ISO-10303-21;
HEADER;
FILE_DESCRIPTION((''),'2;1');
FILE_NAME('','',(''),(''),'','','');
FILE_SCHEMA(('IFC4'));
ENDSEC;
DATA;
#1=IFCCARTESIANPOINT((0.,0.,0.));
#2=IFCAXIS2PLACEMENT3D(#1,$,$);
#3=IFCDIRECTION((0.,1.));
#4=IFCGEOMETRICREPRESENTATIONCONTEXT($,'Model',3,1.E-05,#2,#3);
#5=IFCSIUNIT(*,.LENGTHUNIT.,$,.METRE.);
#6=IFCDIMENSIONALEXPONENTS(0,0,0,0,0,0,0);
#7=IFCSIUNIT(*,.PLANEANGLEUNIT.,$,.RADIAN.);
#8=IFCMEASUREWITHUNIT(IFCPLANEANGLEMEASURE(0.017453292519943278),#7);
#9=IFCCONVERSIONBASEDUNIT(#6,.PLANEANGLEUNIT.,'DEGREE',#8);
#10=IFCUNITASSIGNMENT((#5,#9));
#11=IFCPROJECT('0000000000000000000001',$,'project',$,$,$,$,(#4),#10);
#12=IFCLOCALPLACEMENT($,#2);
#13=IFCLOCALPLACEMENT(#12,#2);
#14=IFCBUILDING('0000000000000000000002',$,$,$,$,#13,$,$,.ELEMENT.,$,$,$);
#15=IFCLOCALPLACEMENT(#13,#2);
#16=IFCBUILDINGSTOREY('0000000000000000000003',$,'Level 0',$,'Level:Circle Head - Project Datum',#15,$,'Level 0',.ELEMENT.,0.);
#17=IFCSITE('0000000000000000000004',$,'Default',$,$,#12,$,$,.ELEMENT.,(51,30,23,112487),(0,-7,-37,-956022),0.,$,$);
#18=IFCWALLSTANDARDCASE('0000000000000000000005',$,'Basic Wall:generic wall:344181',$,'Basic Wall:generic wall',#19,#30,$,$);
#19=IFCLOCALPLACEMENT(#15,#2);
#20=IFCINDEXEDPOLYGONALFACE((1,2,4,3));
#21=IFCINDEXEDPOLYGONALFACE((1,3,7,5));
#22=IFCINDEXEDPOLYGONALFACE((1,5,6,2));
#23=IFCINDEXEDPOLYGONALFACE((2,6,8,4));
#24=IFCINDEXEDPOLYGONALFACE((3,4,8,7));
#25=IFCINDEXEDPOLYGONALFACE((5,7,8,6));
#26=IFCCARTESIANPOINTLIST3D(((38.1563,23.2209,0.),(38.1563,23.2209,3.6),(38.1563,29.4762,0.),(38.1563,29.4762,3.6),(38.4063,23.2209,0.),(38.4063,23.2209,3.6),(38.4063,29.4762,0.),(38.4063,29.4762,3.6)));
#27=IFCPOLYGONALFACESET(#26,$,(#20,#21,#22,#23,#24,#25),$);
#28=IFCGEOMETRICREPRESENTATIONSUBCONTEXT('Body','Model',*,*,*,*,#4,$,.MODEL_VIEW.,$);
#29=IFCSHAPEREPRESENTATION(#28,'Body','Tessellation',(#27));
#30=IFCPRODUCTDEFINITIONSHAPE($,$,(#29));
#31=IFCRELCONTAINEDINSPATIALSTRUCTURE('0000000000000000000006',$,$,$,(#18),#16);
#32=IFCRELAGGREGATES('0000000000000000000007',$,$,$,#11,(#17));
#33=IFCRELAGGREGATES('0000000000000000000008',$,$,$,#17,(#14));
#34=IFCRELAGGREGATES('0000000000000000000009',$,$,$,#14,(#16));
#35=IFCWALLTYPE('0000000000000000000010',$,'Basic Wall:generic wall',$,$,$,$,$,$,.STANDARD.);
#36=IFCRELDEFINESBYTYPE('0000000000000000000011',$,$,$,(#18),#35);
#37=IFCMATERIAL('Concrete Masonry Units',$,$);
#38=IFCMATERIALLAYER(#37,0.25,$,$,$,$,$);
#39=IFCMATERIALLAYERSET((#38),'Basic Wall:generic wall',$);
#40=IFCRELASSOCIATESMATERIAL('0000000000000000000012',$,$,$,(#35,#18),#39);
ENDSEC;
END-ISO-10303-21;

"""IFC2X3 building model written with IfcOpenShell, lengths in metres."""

from ifc_helpers import new_model, entity, si_unit, converted_unit, direction, frame, frame_2d, origin, place, context, subcontext, project, spatial, rectangle, extrude, material, layer, layer_set, layer_usage, type_object, element, save


model = new_model("IFC2X3")

# Units and contexts
model_context = context("Model", 3, precision=1e-05, world=origin(), true_north=direction((0.0, 1.0)))
body_context = subcontext(model_context, "Body", "Model", "MODEL_VIEW")
ifc_project = project(units=[si_unit("LENGTHUNIT", "METRE"), converted_unit("PLANEANGLEUNIT", "DEGREE", entity("IfcPlaneAngleMeasure", 0.017453292519943278), si_unit("PLANEANGLEUNIT", "RADIAN"), dimensions=[0, 0, 0, 0, 0, 0, 0])], contexts=[model_context])

# Site, building, storey
site_placement = place(None, origin())
site = spatial("IfcSite", under=ifc_project, at=site_placement, Name="Default", CompositionType="ELEMENT", RefLatitude=(51, 30, 23, 112487), RefLongitude=(0, -7, -37, -956022), RefElevation=0.0)
building_placement = place(site_placement, origin())
building = spatial("IfcBuilding", under=site, at=building_placement, CompositionType="ELEMENT")
storey_placement = place(building_placement, origin())
storey = spatial("IfcBuildingStorey", under=building, at=storey_placement, Name="Level 0", ObjectType="Level:Circle Head - Project Datum", LongName="Level 0", CompositionType="ELEMENT", Elevation=0.0)

# Shared definitions
ifc_material = material(Name="Concrete Masonry Units")
ifc_layer = layer(ifc_material, 0.25)
ifc_layer_set = layer_set([ifc_layer], Name="Basic Wall:generic wall")
wall_type = type_object("IfcWallType", Name="Basic Wall:generic wall", PredefinedType="STANDARD", material=ifc_layer_set)

# Wall
ifc_layer_usage_1 = layer_usage(ifc_layer_set, "AXIS2", "NEGATIVE", 0.125)
wall_1_placement = place(storey_placement, frame((38.2813, 23.2209, 0.0), z_axis=(0.0, 0.0, 1.0), x_axis=(0.0, 1.0, 0.0)))
element("IfcWallStandardCase", 1, at=wall_1_placement, inside=storey, type_object=wall_type, material=ifc_layer_usage_1, Name="Basic Wall:generic wall:344181", ObjectType="Basic Wall:generic wall", context=body_context, shape_type="SweptSolid", body=[
    extrude(rectangle(XDim=6.2553, YDim=0.25, at=frame_2d((3.1276, 0.0), x_axis=(-1.0, 0.0))), origin(), (0.0, 0.0, 1.0), 3.6),
])

save(model, "model.ifc")
